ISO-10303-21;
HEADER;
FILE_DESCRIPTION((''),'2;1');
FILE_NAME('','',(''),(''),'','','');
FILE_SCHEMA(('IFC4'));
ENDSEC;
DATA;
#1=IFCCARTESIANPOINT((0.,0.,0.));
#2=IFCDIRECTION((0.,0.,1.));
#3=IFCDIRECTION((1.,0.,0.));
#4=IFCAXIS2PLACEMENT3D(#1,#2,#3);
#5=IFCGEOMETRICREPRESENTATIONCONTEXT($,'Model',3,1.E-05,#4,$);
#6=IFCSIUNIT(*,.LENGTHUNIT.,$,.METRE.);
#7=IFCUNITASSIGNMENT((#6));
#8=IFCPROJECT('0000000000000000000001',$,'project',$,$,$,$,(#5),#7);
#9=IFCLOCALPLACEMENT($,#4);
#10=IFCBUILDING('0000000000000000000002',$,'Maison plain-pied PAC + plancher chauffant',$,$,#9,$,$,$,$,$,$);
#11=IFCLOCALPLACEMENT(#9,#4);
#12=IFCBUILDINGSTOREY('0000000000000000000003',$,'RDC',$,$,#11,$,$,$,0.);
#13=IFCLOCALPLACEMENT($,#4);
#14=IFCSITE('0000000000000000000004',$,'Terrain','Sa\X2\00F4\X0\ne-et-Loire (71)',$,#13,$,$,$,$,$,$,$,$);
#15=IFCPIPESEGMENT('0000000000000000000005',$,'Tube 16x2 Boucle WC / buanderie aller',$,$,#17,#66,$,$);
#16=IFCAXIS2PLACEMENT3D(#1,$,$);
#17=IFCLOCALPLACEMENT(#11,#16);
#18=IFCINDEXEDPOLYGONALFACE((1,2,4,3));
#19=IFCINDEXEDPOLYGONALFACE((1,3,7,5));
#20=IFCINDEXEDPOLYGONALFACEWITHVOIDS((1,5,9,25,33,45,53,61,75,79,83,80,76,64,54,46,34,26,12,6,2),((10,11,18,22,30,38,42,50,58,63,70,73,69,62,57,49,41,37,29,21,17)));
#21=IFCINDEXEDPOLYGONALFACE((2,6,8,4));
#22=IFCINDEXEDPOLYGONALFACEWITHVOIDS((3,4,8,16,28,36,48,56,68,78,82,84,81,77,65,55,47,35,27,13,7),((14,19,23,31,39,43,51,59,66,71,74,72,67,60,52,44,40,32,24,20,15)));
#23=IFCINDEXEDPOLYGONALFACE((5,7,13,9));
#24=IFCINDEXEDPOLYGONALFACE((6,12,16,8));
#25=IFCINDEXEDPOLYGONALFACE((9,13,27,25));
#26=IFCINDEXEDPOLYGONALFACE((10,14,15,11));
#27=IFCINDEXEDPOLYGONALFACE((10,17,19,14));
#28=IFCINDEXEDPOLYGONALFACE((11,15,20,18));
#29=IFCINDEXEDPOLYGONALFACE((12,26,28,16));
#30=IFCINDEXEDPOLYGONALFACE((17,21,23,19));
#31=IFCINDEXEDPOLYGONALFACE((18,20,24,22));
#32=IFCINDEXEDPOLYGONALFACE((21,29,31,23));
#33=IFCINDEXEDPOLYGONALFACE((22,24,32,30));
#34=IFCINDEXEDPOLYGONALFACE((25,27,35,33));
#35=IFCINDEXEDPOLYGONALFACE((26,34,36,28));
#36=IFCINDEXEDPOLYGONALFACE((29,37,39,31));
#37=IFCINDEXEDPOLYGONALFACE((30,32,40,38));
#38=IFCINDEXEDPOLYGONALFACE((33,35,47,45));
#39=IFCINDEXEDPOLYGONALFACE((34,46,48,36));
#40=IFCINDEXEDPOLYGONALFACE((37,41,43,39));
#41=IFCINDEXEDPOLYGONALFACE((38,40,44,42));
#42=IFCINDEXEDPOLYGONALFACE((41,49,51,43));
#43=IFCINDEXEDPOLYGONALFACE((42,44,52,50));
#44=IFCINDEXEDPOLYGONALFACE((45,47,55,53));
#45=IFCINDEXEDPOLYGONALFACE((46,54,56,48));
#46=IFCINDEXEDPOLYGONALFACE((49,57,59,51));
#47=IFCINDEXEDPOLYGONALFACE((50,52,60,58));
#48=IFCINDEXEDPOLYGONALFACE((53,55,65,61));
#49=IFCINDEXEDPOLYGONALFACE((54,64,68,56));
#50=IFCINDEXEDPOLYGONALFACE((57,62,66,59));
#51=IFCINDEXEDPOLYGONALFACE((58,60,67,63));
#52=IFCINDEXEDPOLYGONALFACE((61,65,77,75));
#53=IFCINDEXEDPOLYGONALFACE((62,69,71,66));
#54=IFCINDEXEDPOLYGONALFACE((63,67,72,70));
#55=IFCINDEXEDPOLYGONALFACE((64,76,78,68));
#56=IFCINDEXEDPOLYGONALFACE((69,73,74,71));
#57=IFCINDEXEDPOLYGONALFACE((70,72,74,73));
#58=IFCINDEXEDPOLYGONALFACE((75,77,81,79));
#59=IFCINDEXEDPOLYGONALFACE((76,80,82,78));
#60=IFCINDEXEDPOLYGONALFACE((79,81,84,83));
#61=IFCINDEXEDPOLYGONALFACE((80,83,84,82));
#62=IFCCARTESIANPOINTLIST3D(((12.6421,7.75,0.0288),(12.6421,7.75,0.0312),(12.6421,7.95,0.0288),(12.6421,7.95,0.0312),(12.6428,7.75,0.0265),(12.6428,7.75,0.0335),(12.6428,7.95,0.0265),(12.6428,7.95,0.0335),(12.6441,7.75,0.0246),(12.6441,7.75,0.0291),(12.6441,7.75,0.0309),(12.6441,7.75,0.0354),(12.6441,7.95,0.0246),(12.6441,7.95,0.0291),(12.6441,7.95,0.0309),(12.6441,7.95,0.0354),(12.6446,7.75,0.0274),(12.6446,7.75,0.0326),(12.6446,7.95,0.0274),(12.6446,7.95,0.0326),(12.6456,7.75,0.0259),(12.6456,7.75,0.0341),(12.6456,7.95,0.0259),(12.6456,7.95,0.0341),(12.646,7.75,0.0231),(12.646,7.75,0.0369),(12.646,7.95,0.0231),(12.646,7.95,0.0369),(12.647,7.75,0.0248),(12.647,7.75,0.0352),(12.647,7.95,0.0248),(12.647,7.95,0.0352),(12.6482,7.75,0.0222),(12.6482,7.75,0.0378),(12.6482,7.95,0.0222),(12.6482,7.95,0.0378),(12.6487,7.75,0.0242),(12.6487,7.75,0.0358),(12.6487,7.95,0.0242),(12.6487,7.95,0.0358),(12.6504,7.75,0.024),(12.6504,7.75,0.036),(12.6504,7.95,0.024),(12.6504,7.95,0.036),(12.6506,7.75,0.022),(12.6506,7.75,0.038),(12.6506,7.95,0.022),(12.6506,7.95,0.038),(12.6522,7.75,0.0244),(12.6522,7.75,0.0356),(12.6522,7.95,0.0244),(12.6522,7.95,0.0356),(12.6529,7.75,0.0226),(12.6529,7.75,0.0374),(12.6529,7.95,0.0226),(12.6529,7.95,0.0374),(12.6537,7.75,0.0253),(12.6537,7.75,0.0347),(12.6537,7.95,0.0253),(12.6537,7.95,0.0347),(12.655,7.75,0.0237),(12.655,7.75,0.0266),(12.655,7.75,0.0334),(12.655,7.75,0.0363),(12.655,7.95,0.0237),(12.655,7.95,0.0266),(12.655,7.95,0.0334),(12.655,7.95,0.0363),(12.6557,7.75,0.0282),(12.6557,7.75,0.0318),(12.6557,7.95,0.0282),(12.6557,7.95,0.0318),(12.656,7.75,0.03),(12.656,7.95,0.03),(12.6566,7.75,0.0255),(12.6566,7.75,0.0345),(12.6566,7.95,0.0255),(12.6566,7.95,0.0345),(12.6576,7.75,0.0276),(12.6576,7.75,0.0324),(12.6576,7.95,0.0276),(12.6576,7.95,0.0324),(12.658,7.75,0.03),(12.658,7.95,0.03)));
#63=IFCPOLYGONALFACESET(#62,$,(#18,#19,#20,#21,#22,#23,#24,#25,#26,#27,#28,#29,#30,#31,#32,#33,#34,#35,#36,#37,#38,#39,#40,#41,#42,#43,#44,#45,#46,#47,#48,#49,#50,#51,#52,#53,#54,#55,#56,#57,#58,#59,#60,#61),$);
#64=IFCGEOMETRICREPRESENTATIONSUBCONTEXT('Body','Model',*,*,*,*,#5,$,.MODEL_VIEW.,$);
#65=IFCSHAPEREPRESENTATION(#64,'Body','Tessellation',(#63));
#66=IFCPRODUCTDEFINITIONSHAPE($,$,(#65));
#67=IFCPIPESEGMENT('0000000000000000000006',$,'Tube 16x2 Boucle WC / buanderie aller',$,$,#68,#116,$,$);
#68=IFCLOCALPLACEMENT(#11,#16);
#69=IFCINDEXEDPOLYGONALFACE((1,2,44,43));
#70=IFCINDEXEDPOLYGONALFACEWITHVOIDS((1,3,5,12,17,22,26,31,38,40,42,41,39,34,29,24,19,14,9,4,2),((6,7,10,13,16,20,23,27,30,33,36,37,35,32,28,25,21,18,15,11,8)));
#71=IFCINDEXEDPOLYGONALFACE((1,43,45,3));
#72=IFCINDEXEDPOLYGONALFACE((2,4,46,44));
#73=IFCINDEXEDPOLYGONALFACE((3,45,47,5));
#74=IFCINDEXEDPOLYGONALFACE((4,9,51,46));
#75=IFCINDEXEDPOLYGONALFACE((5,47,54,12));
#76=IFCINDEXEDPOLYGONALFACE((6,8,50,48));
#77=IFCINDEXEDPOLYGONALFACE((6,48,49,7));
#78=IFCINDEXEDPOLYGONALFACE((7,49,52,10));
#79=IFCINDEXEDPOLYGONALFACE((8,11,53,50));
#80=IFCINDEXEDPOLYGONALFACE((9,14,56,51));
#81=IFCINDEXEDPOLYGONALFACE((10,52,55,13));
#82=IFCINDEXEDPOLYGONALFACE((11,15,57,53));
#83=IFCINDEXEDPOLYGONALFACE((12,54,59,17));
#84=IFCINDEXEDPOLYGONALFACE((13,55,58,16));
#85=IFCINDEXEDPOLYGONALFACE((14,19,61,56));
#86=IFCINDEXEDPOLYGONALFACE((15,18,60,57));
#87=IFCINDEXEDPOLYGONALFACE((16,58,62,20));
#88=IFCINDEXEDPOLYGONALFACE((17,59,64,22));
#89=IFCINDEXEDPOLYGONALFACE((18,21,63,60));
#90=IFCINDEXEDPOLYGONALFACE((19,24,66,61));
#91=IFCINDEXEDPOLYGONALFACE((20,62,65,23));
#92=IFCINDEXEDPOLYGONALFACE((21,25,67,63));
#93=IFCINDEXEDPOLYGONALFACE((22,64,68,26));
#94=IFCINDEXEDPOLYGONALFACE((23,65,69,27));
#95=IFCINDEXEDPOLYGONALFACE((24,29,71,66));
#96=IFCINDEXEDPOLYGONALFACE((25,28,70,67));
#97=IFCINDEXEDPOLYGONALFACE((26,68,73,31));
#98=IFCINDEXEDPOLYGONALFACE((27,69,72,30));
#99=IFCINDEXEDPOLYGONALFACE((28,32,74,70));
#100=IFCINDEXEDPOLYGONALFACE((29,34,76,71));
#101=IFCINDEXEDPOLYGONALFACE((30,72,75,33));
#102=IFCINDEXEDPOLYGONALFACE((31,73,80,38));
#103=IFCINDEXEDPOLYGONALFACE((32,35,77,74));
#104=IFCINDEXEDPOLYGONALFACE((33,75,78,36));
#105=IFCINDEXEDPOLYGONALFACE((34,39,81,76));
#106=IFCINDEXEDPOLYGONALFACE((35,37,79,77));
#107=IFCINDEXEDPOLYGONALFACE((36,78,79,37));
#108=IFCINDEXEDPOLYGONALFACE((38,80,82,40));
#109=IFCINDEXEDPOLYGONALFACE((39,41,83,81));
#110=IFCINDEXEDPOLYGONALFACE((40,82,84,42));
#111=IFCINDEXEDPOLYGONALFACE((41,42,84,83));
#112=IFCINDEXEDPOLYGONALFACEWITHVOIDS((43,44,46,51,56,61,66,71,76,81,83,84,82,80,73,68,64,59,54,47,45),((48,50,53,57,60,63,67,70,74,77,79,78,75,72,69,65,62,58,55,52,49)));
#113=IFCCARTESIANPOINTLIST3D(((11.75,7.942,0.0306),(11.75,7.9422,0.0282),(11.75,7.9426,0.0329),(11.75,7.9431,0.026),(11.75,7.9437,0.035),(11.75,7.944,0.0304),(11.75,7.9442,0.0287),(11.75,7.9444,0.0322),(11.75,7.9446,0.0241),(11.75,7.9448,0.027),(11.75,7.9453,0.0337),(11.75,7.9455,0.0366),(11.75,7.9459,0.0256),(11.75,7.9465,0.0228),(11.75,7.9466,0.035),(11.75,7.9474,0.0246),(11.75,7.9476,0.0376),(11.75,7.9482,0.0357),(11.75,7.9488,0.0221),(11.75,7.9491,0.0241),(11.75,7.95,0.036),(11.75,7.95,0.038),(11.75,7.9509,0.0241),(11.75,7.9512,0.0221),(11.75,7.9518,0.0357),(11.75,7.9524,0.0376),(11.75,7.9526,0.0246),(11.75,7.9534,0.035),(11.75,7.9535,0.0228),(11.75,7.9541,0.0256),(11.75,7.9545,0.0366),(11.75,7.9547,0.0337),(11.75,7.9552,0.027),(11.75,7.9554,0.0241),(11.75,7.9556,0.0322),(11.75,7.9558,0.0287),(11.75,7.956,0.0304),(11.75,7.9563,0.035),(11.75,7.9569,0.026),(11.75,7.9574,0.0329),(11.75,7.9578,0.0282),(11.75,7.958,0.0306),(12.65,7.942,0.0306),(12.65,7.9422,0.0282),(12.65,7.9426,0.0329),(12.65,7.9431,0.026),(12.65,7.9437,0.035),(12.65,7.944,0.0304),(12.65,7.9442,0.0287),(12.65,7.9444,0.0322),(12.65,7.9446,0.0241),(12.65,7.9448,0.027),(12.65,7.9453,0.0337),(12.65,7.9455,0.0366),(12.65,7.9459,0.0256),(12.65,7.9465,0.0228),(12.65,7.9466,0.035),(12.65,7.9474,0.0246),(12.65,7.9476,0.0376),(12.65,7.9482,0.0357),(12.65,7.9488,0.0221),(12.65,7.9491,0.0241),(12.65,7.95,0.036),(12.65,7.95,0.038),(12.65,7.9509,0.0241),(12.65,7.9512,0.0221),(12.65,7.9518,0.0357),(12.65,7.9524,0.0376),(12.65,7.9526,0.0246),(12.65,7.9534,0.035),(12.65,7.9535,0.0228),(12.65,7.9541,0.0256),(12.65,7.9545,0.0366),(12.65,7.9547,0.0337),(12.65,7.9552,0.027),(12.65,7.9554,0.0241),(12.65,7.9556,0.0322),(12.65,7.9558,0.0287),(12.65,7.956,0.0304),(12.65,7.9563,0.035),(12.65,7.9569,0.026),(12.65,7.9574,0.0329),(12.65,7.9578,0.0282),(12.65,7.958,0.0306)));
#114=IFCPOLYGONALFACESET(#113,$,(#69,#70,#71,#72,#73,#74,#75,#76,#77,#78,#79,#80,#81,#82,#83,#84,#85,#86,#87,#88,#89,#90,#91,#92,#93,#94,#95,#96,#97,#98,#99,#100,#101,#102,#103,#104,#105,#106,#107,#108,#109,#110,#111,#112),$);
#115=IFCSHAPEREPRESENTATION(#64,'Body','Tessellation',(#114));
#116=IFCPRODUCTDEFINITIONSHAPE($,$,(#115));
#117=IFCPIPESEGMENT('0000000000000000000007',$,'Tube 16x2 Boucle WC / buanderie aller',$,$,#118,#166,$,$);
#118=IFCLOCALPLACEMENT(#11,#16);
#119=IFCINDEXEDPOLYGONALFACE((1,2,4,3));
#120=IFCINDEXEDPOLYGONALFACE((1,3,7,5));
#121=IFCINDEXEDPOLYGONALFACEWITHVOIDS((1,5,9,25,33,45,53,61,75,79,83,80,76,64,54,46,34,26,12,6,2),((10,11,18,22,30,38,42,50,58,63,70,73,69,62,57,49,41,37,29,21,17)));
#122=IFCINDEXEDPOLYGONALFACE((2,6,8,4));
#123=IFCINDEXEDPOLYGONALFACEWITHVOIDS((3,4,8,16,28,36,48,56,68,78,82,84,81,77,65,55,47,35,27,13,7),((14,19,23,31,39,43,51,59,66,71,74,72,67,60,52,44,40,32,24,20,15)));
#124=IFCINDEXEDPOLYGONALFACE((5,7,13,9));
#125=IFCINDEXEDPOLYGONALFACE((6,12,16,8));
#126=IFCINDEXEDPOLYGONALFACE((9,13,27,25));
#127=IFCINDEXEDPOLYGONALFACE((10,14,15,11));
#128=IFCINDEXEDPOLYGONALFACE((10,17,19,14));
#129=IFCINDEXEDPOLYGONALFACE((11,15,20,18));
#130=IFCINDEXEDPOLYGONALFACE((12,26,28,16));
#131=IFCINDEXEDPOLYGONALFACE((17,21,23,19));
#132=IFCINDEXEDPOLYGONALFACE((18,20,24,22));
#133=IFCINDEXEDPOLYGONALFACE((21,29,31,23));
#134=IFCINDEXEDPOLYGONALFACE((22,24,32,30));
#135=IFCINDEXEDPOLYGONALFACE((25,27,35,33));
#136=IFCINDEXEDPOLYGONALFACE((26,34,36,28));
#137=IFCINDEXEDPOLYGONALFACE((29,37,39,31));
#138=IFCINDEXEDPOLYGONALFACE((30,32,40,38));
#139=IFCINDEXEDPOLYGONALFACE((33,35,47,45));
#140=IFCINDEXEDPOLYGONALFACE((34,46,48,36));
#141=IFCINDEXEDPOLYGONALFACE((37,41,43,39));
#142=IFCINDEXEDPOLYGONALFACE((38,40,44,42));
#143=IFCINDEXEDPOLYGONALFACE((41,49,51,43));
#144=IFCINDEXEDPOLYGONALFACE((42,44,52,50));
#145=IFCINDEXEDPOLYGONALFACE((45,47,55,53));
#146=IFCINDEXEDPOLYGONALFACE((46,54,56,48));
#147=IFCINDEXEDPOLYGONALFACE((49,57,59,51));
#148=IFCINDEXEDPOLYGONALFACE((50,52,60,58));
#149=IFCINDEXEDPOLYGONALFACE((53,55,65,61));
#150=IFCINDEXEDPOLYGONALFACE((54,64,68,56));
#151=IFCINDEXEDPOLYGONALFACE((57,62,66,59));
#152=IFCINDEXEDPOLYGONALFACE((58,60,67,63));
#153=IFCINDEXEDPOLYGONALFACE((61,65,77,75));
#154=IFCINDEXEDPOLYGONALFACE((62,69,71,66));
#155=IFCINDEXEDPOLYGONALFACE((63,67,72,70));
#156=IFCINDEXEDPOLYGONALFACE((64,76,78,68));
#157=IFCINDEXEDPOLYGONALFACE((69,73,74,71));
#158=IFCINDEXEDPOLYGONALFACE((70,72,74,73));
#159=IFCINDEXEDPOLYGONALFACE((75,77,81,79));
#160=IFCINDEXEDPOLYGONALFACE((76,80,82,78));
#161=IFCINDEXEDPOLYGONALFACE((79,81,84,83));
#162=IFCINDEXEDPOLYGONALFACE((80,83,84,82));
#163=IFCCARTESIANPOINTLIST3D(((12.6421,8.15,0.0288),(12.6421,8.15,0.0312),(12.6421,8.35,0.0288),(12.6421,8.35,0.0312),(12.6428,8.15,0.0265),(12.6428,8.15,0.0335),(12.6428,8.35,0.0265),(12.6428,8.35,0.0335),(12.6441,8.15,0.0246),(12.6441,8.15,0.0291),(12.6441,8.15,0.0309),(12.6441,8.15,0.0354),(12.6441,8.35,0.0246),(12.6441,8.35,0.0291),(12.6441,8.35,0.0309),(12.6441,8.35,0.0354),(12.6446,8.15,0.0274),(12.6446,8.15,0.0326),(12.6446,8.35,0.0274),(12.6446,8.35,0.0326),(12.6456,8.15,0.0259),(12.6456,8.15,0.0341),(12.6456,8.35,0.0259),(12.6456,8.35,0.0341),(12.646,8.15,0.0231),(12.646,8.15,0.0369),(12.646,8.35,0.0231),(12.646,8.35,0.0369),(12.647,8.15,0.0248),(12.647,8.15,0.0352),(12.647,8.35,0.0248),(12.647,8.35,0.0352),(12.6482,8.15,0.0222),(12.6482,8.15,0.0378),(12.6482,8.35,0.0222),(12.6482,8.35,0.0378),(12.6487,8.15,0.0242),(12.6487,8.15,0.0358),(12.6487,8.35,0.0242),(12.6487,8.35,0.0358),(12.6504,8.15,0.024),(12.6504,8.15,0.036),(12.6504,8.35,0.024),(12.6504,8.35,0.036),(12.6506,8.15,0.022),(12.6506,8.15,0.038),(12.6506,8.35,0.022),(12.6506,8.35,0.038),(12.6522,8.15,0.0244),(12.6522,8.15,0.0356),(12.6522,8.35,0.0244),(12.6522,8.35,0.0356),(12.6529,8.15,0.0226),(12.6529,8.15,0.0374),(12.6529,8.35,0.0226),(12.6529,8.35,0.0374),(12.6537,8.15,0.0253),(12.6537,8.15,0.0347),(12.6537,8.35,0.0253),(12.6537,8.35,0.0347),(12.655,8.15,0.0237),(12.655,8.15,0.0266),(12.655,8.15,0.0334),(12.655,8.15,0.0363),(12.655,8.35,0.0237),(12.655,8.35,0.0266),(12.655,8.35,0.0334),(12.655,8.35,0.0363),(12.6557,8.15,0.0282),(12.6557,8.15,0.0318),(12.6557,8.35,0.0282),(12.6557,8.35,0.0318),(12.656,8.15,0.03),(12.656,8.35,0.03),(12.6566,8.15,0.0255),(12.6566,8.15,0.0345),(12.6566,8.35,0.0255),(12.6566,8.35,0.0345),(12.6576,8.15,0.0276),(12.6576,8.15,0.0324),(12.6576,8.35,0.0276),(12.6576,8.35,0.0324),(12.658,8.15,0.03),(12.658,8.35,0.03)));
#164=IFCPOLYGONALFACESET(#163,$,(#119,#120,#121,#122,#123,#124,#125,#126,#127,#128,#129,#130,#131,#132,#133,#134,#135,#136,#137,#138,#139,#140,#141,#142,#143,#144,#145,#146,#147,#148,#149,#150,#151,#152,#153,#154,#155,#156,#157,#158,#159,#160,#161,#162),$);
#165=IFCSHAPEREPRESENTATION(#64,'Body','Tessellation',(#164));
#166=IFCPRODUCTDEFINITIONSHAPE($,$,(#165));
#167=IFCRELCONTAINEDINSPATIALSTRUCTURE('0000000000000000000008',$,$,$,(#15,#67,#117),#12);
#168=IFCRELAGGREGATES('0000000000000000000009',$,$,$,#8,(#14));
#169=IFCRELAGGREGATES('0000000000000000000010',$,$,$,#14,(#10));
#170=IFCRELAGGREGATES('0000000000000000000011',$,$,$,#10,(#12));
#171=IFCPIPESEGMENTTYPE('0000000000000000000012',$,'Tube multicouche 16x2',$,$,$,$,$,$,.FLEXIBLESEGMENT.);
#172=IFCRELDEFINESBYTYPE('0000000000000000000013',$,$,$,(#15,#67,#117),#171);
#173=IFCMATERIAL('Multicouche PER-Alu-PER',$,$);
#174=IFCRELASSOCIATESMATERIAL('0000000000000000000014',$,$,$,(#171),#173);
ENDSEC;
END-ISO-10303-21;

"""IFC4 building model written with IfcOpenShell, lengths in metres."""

from ifc_helpers import new_model, si_unit, frame, origin_with_axes, place, context, subcontext, project, spatial, hollow_circle, extrude, material, type_object, element, save


model = new_model("IFC4")

# Units and contexts
model_context = context("Model", 3, precision=1e-05, world=origin_with_axes())
body_context = subcontext(model_context, "Body", "Model", "MODEL_VIEW")
ifc_project = project(units=[si_unit("LENGTHUNIT", "METRE")], contexts=[model_context])

# Site, building, storey
site_placement = place(None, origin_with_axes())
site = spatial("IfcSite", under=ifc_project, at=site_placement, Name="Terrain", Description="Saône-et-Loire (71)")
building_placement = place(None, origin_with_axes())
building = spatial("IfcBuilding", under=site, at=building_placement, Name="Maison plain-pied PAC + plancher chauffant")
storey_placement = place(building_placement, origin_with_axes())
storey = spatial("IfcBuildingStorey", under=building, at=storey_placement, Name="RDC", Elevation=0.0)

# Pipe segments
ifc_material_1 = material(Name="Multicouche PER-Alu-PER")
pipe_segment_type_1 = type_object("IfcPipeSegmentType", Name="Tube multicouche 16x2", PredefinedType="FLEXIBLESEGMENT", material=ifc_material_1)
pipe_segment_1_placement = place(storey_placement, frame((12.65, 7.75, 0.03), z_axis=(0.0, 1.0, 0.0), x_axis=(1.0, 0.0, 0.0)))
element("IfcPipeSegment", 1, at=pipe_segment_1_placement, inside=storey, type_object=pipe_segment_type_1, Name="Tube 16x2 Boucle WC / buanderie aller", context=body_context, shape_type="SweptSolid", body=[
    extrude(hollow_circle(Radius=0.008, WallThickness=0.002), origin_with_axes(), (0.0, 0.0, 1.0), 0.2),
])
pipe_segment_2_placement = place(storey_placement, frame((12.65, 7.95, 0.03), z_axis=(-1.0, 0.0, 0.0), x_axis=(0.0, 0.0, 1.0)))
element("IfcPipeSegment", 2, at=pipe_segment_2_placement, inside=storey, type_object=pipe_segment_type_1, Name="Tube 16x2 Boucle WC / buanderie aller", context=body_context, shape_type="SweptSolid", body=[
    extrude(hollow_circle(Radius=0.008, WallThickness=0.002), origin_with_axes(), (0.0, 0.0, 1.0), 0.9),
])
pipe_segment_3_placement = place(storey_placement, frame((12.65, 8.15, 0.03), z_axis=(0.0, 1.0, 0.0), x_axis=(1.0, 0.0, 0.0)))
element("IfcPipeSegment", 3, at=pipe_segment_3_placement, inside=storey, type_object=pipe_segment_type_1, Name="Tube 16x2 Boucle WC / buanderie aller", context=body_context, shape_type="SweptSolid", body=[
    extrude(hollow_circle(Radius=0.008, WallThickness=0.002), origin_with_axes(), (0.0, 0.0, 1.0), 0.2),
])

save(model, "model.ifc")
